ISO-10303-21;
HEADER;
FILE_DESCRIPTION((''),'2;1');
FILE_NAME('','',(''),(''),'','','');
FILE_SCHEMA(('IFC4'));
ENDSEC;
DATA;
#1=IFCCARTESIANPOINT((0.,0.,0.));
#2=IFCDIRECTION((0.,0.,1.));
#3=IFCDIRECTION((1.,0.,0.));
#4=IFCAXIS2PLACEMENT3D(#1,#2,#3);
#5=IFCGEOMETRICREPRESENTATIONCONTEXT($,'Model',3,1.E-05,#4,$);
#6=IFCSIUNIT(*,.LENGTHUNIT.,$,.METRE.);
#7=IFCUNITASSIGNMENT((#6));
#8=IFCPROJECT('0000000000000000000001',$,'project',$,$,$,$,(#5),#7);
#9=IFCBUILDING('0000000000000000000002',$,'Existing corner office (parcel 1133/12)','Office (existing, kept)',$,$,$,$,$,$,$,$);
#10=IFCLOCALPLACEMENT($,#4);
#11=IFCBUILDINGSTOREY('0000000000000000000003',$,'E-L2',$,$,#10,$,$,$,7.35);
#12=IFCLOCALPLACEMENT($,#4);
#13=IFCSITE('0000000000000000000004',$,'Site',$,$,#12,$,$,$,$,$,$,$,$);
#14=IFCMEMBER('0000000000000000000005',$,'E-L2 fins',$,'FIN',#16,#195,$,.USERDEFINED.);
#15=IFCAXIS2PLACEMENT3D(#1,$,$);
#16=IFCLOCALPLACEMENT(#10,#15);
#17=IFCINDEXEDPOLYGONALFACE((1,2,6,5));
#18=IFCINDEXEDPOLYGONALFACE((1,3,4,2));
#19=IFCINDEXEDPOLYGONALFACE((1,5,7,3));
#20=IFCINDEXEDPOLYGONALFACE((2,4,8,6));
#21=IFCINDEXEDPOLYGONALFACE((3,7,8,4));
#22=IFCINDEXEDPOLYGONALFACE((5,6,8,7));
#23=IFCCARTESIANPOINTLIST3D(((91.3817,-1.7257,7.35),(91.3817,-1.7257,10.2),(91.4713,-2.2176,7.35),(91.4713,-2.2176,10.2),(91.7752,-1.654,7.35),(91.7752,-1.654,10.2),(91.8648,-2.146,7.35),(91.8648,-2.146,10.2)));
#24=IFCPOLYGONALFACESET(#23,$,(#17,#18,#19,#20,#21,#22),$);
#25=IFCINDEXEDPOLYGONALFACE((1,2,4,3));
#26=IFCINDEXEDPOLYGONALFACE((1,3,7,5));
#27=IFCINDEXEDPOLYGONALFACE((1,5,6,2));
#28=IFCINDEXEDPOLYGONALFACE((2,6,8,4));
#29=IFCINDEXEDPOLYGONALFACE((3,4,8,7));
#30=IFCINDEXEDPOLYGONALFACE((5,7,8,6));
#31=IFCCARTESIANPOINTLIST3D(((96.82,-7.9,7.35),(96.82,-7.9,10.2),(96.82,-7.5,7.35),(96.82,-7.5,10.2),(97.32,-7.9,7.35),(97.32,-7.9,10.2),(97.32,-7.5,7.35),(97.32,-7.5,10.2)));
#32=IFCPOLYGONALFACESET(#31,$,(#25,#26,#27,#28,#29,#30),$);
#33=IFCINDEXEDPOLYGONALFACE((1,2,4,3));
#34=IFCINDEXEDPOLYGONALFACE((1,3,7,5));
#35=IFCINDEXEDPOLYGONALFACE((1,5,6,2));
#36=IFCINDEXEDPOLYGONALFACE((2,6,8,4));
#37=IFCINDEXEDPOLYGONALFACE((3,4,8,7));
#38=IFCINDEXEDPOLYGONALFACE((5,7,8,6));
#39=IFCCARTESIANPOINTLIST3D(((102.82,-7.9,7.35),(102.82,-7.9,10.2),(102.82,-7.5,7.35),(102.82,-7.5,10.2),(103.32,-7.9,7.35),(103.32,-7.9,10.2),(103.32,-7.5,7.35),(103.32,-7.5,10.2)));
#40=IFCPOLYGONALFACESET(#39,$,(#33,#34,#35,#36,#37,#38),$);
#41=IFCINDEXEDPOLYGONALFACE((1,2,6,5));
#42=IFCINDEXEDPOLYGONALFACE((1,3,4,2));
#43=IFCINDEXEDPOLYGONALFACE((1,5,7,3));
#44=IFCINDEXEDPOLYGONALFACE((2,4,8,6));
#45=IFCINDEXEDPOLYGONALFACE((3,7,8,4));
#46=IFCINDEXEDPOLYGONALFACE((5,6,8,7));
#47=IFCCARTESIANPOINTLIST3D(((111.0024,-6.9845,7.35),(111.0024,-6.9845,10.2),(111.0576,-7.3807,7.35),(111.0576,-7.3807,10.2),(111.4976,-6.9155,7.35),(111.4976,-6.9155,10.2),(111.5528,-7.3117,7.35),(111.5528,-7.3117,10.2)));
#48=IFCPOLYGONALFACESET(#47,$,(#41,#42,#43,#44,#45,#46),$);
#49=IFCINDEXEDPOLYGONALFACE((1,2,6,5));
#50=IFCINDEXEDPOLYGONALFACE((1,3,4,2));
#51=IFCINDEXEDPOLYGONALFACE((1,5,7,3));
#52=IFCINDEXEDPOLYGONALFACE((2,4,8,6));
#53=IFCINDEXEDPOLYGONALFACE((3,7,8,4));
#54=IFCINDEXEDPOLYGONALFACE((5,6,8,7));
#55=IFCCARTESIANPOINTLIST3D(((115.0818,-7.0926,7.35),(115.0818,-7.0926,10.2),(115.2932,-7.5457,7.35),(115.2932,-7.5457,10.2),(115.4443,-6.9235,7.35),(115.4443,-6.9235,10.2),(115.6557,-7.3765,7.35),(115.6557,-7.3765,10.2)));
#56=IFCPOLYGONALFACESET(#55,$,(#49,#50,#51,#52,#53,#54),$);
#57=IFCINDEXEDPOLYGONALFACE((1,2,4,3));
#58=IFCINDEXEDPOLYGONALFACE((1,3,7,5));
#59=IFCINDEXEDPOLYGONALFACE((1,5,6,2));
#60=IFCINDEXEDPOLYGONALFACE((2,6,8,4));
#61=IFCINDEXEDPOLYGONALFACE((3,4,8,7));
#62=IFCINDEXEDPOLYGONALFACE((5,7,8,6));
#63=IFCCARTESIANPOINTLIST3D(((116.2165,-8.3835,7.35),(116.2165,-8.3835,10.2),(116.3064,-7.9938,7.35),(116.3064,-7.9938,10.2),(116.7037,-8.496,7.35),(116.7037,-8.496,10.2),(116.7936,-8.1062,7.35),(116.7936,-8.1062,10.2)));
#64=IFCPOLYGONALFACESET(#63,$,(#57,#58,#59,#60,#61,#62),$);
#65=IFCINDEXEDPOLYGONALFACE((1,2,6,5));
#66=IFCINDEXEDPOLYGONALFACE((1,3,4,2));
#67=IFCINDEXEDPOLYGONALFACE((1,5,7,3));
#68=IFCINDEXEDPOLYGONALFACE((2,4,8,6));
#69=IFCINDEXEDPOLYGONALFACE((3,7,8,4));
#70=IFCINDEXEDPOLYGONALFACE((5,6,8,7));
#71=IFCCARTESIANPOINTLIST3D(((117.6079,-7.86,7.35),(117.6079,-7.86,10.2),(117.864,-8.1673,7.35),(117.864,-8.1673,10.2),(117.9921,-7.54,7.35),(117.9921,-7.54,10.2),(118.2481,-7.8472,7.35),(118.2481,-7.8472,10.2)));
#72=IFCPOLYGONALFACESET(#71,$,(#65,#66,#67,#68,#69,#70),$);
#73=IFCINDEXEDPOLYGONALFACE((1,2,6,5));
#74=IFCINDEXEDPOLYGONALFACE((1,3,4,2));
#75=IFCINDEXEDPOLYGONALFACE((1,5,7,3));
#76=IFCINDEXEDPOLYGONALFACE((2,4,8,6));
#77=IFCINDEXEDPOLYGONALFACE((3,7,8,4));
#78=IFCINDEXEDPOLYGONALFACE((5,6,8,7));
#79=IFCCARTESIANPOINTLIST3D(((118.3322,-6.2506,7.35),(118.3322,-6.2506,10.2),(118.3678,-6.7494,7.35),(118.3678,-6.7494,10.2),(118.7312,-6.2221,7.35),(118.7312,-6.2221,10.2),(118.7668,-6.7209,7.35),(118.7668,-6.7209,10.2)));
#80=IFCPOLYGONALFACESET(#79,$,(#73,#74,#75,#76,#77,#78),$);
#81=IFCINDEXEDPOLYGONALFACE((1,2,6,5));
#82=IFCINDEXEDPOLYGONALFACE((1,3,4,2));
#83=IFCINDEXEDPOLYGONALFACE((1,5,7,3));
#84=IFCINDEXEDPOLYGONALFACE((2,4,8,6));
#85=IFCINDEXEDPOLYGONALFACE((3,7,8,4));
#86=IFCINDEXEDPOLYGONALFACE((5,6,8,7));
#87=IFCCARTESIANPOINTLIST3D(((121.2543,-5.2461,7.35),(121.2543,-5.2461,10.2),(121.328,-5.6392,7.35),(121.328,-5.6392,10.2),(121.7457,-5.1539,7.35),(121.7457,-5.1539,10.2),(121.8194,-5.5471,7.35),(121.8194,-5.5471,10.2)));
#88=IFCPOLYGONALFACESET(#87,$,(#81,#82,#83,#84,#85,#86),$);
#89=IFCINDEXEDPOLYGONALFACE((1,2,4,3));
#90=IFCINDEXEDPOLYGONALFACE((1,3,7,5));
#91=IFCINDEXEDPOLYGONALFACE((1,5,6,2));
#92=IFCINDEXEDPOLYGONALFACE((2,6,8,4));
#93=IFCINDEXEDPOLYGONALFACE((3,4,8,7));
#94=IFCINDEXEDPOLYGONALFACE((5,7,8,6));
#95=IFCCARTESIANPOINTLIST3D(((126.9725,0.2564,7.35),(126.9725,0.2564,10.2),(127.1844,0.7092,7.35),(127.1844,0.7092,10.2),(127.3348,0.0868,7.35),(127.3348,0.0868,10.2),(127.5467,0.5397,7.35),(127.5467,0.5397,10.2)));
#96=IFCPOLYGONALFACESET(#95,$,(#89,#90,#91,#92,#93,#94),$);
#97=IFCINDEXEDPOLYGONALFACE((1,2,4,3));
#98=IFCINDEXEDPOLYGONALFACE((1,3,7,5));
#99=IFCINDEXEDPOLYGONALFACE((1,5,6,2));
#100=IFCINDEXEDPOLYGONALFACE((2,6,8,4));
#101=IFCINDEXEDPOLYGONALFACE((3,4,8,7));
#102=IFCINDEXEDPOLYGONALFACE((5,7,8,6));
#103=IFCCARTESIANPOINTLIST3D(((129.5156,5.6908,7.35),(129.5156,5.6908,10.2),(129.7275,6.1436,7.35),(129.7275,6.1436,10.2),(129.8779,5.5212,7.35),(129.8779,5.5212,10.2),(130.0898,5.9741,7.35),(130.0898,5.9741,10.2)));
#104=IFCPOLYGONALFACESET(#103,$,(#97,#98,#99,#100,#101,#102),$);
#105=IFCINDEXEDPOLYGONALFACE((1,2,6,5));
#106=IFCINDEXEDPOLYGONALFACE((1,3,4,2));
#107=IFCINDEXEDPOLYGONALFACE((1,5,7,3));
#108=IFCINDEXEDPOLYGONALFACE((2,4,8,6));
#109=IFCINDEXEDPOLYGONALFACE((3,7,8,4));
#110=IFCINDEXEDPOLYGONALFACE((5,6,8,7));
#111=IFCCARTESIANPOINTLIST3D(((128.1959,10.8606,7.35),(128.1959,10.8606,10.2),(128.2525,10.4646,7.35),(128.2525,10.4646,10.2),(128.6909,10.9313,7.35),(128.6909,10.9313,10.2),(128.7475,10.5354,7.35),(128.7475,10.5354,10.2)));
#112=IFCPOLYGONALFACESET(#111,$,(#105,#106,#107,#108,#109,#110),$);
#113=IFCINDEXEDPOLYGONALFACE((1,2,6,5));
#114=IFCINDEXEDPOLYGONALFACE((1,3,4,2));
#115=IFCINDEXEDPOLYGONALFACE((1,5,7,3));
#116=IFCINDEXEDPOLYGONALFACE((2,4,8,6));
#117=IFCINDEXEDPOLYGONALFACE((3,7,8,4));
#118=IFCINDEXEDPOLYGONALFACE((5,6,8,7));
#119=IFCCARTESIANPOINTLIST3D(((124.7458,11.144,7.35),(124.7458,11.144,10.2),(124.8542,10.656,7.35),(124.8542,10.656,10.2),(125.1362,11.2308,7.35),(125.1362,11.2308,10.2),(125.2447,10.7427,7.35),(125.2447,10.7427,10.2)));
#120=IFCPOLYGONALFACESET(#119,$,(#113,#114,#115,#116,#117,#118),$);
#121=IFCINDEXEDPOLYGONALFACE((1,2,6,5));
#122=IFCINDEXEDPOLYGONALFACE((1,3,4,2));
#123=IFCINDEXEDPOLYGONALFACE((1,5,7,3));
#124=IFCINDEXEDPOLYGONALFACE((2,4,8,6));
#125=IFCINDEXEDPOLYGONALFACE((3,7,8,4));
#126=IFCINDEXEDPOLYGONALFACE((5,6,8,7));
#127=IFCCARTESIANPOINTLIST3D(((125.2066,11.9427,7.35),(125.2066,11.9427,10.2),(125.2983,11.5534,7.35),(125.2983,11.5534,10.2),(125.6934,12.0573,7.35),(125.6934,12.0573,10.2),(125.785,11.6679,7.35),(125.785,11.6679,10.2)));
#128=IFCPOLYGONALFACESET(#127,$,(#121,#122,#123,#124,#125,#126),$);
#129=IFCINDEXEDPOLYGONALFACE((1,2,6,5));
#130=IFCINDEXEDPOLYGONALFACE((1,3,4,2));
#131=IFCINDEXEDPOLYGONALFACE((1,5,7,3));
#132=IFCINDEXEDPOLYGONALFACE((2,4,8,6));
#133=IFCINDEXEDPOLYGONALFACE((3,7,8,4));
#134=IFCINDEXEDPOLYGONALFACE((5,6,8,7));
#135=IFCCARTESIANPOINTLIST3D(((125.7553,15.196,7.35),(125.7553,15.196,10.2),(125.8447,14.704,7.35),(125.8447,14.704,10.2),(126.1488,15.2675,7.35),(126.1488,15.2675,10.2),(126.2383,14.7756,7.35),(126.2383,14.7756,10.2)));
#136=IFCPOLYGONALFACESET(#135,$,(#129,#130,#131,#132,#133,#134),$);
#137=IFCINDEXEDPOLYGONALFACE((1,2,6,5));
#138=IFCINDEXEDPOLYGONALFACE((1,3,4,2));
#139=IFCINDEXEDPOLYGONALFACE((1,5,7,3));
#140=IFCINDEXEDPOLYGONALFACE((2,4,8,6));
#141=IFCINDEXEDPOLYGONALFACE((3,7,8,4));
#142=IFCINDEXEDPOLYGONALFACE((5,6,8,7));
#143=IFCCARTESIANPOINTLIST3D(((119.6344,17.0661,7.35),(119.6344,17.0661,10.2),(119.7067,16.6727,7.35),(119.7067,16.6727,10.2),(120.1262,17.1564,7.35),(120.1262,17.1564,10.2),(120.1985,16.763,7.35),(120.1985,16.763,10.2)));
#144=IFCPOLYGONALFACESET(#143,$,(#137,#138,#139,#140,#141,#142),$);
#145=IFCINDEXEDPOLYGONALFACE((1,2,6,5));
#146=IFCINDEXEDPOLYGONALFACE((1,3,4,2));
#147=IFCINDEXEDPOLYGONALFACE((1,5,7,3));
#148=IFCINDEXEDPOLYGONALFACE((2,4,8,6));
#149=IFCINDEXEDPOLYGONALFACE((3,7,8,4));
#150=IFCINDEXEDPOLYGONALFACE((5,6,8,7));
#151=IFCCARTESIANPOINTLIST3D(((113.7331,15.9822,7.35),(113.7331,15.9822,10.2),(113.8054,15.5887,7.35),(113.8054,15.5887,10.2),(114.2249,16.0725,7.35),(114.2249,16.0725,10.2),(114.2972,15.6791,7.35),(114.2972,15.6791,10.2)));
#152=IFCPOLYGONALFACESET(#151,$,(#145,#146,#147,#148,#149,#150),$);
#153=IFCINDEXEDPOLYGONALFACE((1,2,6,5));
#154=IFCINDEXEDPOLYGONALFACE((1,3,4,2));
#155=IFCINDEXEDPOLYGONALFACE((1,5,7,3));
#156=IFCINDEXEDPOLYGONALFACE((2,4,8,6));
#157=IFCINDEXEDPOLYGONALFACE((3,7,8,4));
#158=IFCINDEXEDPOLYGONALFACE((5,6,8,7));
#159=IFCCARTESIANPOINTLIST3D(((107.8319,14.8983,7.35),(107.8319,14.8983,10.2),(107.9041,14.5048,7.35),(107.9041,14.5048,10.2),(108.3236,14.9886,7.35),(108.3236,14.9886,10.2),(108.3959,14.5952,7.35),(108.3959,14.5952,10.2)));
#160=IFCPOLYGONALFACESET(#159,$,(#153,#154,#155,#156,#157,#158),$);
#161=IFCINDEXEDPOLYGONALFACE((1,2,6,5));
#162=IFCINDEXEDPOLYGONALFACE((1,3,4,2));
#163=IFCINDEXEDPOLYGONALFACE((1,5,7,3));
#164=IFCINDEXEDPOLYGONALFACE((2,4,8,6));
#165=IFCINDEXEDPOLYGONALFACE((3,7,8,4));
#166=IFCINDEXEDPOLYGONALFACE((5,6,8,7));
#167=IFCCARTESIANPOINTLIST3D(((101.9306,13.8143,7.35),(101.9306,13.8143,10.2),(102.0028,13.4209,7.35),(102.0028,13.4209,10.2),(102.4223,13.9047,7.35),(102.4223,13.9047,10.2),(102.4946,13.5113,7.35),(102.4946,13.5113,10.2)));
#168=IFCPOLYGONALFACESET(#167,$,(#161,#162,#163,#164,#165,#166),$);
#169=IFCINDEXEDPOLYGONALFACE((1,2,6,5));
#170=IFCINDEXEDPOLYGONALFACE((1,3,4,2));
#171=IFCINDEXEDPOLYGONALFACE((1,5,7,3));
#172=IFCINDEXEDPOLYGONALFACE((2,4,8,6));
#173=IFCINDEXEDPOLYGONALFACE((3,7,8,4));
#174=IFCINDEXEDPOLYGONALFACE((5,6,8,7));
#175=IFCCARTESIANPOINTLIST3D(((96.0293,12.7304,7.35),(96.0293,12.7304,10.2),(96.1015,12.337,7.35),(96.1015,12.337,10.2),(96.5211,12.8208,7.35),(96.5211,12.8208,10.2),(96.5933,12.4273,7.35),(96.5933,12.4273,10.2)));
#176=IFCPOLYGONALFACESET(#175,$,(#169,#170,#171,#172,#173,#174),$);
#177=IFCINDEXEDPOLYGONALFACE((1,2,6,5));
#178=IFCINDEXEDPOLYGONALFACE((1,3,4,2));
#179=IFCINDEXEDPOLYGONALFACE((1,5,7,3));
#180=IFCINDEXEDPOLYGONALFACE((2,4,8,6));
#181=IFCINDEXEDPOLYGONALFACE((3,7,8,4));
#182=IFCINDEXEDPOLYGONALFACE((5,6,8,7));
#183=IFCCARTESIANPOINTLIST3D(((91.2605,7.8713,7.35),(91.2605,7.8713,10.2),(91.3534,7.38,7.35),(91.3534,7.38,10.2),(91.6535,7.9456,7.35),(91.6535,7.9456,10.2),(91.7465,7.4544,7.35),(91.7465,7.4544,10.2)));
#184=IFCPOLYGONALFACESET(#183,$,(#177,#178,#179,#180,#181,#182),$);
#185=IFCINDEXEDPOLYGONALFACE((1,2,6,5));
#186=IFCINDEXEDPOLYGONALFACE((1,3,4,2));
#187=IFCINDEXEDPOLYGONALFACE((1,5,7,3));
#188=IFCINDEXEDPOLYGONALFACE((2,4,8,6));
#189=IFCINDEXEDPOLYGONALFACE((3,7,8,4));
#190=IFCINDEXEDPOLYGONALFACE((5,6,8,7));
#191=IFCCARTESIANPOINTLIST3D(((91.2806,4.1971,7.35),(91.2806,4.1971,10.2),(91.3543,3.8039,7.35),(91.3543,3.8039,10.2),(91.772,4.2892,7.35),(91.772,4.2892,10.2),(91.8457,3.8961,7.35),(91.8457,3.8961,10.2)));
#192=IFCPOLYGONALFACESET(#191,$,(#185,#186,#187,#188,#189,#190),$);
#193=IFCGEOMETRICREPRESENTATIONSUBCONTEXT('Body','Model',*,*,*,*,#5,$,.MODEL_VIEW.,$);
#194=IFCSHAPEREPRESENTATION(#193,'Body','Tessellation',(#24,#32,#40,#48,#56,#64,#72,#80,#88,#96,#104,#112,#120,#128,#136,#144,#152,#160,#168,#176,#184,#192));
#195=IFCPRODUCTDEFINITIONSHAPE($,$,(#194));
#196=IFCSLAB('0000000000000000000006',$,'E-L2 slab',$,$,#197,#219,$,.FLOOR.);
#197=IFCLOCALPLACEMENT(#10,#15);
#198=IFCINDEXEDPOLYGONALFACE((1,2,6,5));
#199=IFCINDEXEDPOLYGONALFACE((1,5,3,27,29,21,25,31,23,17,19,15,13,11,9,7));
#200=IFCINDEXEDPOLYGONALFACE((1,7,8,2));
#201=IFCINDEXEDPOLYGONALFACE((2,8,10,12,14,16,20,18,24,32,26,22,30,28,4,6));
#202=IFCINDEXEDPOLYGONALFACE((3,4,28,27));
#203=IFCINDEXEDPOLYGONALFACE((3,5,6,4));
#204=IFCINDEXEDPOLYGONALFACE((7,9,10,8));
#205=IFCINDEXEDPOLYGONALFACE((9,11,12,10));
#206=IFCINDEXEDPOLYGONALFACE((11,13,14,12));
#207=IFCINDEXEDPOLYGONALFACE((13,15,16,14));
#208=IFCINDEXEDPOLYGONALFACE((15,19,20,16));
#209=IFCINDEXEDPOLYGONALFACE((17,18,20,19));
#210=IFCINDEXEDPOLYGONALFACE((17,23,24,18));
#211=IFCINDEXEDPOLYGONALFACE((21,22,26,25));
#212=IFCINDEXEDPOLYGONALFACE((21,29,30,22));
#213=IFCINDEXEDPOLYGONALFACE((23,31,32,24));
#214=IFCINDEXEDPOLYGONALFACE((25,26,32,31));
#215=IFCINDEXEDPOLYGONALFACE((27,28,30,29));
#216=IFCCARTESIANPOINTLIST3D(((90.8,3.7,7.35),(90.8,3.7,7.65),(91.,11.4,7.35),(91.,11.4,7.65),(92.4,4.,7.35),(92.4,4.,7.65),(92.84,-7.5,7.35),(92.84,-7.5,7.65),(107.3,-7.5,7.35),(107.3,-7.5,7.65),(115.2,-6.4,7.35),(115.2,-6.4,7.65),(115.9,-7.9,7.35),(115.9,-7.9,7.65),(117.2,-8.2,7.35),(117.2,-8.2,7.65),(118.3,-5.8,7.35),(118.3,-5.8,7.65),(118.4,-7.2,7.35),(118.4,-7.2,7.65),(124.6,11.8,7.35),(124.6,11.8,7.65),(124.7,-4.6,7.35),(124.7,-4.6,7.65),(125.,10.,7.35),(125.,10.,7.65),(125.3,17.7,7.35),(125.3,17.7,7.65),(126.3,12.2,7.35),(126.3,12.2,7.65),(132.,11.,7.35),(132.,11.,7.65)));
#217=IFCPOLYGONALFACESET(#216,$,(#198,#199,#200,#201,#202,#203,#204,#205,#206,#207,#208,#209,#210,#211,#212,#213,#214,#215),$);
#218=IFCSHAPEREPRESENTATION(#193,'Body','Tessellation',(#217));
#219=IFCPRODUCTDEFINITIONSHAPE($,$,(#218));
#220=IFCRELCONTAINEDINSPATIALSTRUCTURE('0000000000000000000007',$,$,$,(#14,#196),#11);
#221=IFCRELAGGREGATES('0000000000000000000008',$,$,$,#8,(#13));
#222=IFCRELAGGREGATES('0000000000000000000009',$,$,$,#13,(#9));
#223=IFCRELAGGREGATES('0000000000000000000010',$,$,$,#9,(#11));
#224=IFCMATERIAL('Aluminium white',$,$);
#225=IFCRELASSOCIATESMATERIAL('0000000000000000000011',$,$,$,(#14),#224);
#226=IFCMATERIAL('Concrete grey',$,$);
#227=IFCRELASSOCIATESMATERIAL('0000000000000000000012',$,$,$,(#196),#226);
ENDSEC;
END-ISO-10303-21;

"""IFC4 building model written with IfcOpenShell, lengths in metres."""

from ifc_helpers import new_model, si_unit, frame, origin_with_axes, place, context, subcontext, project, spatial, polyline, outline, extrude, material, element, save


model = new_model("IFC4")

# Units and contexts
model_context = context("Model", 3, precision=1e-05, world=origin_with_axes())
body_context = subcontext(model_context, "Body", "Model", "MODEL_VIEW")
ifc_project = project(units=[si_unit("LENGTHUNIT", "METRE")], contexts=[model_context])

# Site, building, storey
site_placement = place(None, origin_with_axes())
site = spatial("IfcSite", under=ifc_project, at=site_placement, Name="Site")
building = spatial("IfcBuilding", under=site, Name="Existing corner office (parcel 1133/12)", Description="Office (existing, kept)")
storey_placement = place(None, origin_with_axes())
storey = spatial("IfcBuildingStorey", under=building, at=storey_placement, Name="E-L2", Elevation=7.35)

# Member
ifc_material_1 = material(Name="Aluminium white")
member_1_placement = place(storey_placement, origin_with_axes())
element("IfcMember", 1, at=member_1_placement, inside=storey, material=ifc_material_1, Name="E-L2 fins", ObjectType="FIN", PredefinedType="USERDEFINED", context=body_context, shape_type="SweptSolid", body=[
    extrude(outline(polyline([(-0.2, -0.25), (0.2, -0.25), (0.2, 0.25), (-0.2, 0.25), (-0.2, -0.25)])), frame((91.6232, -1.9358, 7.35), z_axis=(0.0, 0.0, 1.0), x_axis=(-0.983814, -0.179195, 0.0)), (0.0, 0.0, 1.0), 2.85),
    extrude(outline(polyline([(-0.2, -0.25), (0.2, -0.25), (0.2, 0.25), (-0.2, 0.25), (-0.2, -0.25)])), frame((97.07, -7.7, 7.35), z_axis=(0.0, 0.0, 1.0), x_axis=(0.0, -1.0, 0.0)), (0.0, 0.0, 1.0), 2.85),
    extrude(outline(polyline([(-0.2, -0.25), (0.2, -0.25), (0.2, 0.25), (-0.2, 0.25), (-0.2, -0.25)])), frame((103.07, -7.7, 7.35), z_axis=(0.0, 0.0, 1.0), x_axis=(0.0, -1.0, 0.0)), (0.0, 0.0, 1.0), 2.85),
    extrude(outline(polyline([(-0.2, -0.25), (0.2, -0.25), (0.2, 0.25), (-0.2, 0.25), (-0.2, -0.25)])), frame((111.2776, -7.1481, 7.35), z_axis=(0.0, 0.0, 1.0), x_axis=(0.13791, -0.990445, 0.0)), (0.0, 0.0, 1.0), 2.85),
    extrude(outline(polyline([(-0.2, -0.25), (0.2, -0.25), (0.2, 0.25), (-0.2, 0.25), (-0.2, -0.25)])), frame((115.3688, -7.2346, 7.35), z_axis=(0.0, 0.0, 1.0), x_axis=(-0.906183, -0.422885, 0.0)), (0.0, 0.0, 1.0), 2.85),
    extrude(outline(polyline([(-0.2, -0.25), (0.2, -0.25), (0.2, 0.25), (-0.2, 0.25), (-0.2, -0.25)])), frame((116.505, -8.2449, 7.35), z_axis=(0.0, 0.0, 1.0), x_axis=(-0.22486, -0.974391, 0.0)), (0.0, 0.0, 1.0), 2.85),
    extrude(outline(polyline([(-0.2, -0.25), (0.2, -0.25), (0.2, 0.25), (-0.2, 0.25), (-0.2, -0.25)])), frame((117.928, -7.8536, 7.35), z_axis=(0.0, 0.0, 1.0), x_axis=(0.640184, -0.768221, 0.0)), (0.0, 0.0, 1.0), 2.85),
    extrude(outline(polyline([(-0.2, -0.25), (0.2, -0.25), (0.2, 0.25), (-0.2, 0.25), (-0.2, -0.25)])), frame((118.5495, -6.4858, 7.35), z_axis=(0.0, 0.0, 1.0), x_axis=(0.997459, 0.071247, 0.0)), (0.0, 0.0, 1.0), 2.85),
    extrude(outline(polyline([(-0.2, -0.25), (0.2, -0.25), (0.2, 0.25), (-0.2, 0.25), (-0.2, -0.25)])), frame((121.5369, -5.3966, 7.35), z_axis=(0.0, 0.0, 1.0), x_axis=(0.184289, -0.982872, 0.0)), (0.0, 0.0, 1.0), 2.85),
    extrude(outline(polyline([(-0.2, -0.25), (0.2, -0.25), (0.2, 0.25), (-0.2, 0.25), (-0.2, -0.25)])), frame((127.2596, 0.398, 7.35), z_axis=(0.0, 0.0, 1.0), x_axis=(0.905738, -0.423839, 0.0)), (0.0, 0.0, 1.0), 2.85),
    extrude(outline(polyline([(-0.2, -0.25), (0.2, -0.25), (0.2, 0.25), (-0.2, 0.25), (-0.2, -0.25)])), frame((129.8027, 5.8324, 7.35), z_axis=(0.0, 0.0, 1.0), x_axis=(0.905738, -0.423839, 0.0)), (0.0, 0.0, 1.0), 2.85),
    extrude(outline(polyline([(-0.2, -0.25), (0.2, -0.25), (0.2, 0.25), (-0.2, 0.25), (-0.2, -0.25)])), frame((128.4717, 10.698, 7.35), z_axis=(0.0, 0.0, 1.0), x_axis=(-0.141421, 0.989949, 0.0)), (0.0, 0.0, 1.0), 2.85),
    extrude(outline(polyline([(-0.2, -0.25), (0.2, -0.25), (0.2, 0.25), (-0.2, 0.25), (-0.2, -0.25)])), frame((124.9952, 10.9434, 7.35), z_axis=(0.0, 0.0, 1.0), x_axis=(0.976187, 0.21693, 0.0)), (0.0, 0.0, 1.0), 2.85),
    extrude(outline(polyline([(-0.2, -0.25), (0.2, -0.25), (0.2, 0.25), (-0.2, 0.25), (-0.2, -0.25)])), frame((125.4958, 11.8053, 7.35), z_axis=(0.0, 0.0, 1.0), x_axis=(0.229039, -0.973417, 0.0)), (0.0, 0.0, 1.0), 2.85),
    extrude(outline(polyline([(-0.2, -0.25), (0.2, -0.25), (0.2, 0.25), (-0.2, 0.25), (-0.2, -0.25)])), frame((125.9968, 14.9858, 7.35), z_axis=(0.0, 0.0, 1.0), x_axis=(0.98387, 0.178885, 0.0)), (0.0, 0.0, 1.0), 2.85),
    extrude(outline(polyline([(-0.2, -0.25), (0.2, -0.25), (0.2, 0.25), (-0.2, 0.25), (-0.2, -0.25)])), frame((119.9164, 16.9145, 7.35), z_axis=(0.0, 0.0, 1.0), x_axis=(-0.180652, 0.983547, 0.0)), (0.0, 0.0, 1.0), 2.85),
    extrude(outline(polyline([(-0.2, -0.25), (0.2, -0.25), (0.2, 0.25), (-0.2, 0.25), (-0.2, -0.25)])), frame((114.0152, 15.8306, 7.35), z_axis=(0.0, 0.0, 1.0), x_axis=(-0.180652, 0.983547, 0.0)), (0.0, 0.0, 1.0), 2.85),
    extrude(outline(polyline([(-0.2, -0.25), (0.2, -0.25), (0.2, 0.25), (-0.2, 0.25), (-0.2, -0.25)])), frame((108.1139, 14.7467, 7.35), z_axis=(0.0, 0.0, 1.0), x_axis=(-0.180652, 0.983547, 0.0)), (0.0, 0.0, 1.0), 2.85),
    extrude(outline(polyline([(-0.2, -0.25), (0.2, -0.25), (0.2, 0.25), (-0.2, 0.25), (-0.2, -0.25)])), frame((102.2126, 13.6628, 7.35), z_axis=(0.0, 0.0, 1.0), x_axis=(-0.180652, 0.983547, 0.0)), (0.0, 0.0, 1.0), 2.85),
    extrude(outline(polyline([(-0.2, -0.25), (0.2, -0.25), (0.2, 0.25), (-0.2, 0.25), (-0.2, -0.25)])), frame((96.3113, 12.5789, 7.35), z_axis=(0.0, 0.0, 1.0), x_axis=(-0.180652, 0.983547, 0.0)), (0.0, 0.0, 1.0), 2.85),
    extrude(outline(polyline([(-0.2, -0.25), (0.2, -0.25), (0.2, 0.25), (-0.2, 0.25), (-0.2, -0.25)])), frame((91.5035, 7.6628, 7.35), z_axis=(0.0, 0.0, 1.0), x_axis=(-0.98257, -0.185892, 0.0)), (0.0, 0.0, 1.0), 2.85),
    extrude(outline(polyline([(-0.2, -0.25), (0.2, -0.25), (0.2, 0.25), (-0.2, 0.25), (-0.2, -0.25)])), frame((91.5631, 4.0466, 7.35), z_axis=(0.0, 0.0, 1.0), x_axis=(-0.184289, 0.982872, 0.0)), (0.0, 0.0, 1.0), 2.85),
])

# Slab
ifc_material_2 = material(Name="Concrete grey")
slab_1_placement = place(storey_placement, origin_with_axes())
element("IfcSlab", 2, at=slab_1_placement, inside=storey, material=ifc_material_2, Name="E-L2 slab", PredefinedType="FLOOR", context=body_context, shape_type="SweptSolid", body=[
    extrude(outline(polyline([(90.8, 3.7), (92.84, -7.5), (107.3, -7.5), (115.2, -6.4), (115.9, -7.9), (117.2, -8.2), (118.4, -7.2), (118.3, -5.8), (124.7, -4.6), (132.0, 11.0), (125.0, 10.0), (124.6, 11.8), (126.3, 12.2), (125.3, 17.7), (91.0, 11.4), (92.4, 4.0), (90.8, 3.7)])), frame((0.0, 0.0, 7.35), z_axis=(0.0, 0.0, 1.0), x_axis=(1.0, 0.0, 0.0)), (0.0, 0.0, 1.0), 0.3),
])

save(model, "model.ifc")
